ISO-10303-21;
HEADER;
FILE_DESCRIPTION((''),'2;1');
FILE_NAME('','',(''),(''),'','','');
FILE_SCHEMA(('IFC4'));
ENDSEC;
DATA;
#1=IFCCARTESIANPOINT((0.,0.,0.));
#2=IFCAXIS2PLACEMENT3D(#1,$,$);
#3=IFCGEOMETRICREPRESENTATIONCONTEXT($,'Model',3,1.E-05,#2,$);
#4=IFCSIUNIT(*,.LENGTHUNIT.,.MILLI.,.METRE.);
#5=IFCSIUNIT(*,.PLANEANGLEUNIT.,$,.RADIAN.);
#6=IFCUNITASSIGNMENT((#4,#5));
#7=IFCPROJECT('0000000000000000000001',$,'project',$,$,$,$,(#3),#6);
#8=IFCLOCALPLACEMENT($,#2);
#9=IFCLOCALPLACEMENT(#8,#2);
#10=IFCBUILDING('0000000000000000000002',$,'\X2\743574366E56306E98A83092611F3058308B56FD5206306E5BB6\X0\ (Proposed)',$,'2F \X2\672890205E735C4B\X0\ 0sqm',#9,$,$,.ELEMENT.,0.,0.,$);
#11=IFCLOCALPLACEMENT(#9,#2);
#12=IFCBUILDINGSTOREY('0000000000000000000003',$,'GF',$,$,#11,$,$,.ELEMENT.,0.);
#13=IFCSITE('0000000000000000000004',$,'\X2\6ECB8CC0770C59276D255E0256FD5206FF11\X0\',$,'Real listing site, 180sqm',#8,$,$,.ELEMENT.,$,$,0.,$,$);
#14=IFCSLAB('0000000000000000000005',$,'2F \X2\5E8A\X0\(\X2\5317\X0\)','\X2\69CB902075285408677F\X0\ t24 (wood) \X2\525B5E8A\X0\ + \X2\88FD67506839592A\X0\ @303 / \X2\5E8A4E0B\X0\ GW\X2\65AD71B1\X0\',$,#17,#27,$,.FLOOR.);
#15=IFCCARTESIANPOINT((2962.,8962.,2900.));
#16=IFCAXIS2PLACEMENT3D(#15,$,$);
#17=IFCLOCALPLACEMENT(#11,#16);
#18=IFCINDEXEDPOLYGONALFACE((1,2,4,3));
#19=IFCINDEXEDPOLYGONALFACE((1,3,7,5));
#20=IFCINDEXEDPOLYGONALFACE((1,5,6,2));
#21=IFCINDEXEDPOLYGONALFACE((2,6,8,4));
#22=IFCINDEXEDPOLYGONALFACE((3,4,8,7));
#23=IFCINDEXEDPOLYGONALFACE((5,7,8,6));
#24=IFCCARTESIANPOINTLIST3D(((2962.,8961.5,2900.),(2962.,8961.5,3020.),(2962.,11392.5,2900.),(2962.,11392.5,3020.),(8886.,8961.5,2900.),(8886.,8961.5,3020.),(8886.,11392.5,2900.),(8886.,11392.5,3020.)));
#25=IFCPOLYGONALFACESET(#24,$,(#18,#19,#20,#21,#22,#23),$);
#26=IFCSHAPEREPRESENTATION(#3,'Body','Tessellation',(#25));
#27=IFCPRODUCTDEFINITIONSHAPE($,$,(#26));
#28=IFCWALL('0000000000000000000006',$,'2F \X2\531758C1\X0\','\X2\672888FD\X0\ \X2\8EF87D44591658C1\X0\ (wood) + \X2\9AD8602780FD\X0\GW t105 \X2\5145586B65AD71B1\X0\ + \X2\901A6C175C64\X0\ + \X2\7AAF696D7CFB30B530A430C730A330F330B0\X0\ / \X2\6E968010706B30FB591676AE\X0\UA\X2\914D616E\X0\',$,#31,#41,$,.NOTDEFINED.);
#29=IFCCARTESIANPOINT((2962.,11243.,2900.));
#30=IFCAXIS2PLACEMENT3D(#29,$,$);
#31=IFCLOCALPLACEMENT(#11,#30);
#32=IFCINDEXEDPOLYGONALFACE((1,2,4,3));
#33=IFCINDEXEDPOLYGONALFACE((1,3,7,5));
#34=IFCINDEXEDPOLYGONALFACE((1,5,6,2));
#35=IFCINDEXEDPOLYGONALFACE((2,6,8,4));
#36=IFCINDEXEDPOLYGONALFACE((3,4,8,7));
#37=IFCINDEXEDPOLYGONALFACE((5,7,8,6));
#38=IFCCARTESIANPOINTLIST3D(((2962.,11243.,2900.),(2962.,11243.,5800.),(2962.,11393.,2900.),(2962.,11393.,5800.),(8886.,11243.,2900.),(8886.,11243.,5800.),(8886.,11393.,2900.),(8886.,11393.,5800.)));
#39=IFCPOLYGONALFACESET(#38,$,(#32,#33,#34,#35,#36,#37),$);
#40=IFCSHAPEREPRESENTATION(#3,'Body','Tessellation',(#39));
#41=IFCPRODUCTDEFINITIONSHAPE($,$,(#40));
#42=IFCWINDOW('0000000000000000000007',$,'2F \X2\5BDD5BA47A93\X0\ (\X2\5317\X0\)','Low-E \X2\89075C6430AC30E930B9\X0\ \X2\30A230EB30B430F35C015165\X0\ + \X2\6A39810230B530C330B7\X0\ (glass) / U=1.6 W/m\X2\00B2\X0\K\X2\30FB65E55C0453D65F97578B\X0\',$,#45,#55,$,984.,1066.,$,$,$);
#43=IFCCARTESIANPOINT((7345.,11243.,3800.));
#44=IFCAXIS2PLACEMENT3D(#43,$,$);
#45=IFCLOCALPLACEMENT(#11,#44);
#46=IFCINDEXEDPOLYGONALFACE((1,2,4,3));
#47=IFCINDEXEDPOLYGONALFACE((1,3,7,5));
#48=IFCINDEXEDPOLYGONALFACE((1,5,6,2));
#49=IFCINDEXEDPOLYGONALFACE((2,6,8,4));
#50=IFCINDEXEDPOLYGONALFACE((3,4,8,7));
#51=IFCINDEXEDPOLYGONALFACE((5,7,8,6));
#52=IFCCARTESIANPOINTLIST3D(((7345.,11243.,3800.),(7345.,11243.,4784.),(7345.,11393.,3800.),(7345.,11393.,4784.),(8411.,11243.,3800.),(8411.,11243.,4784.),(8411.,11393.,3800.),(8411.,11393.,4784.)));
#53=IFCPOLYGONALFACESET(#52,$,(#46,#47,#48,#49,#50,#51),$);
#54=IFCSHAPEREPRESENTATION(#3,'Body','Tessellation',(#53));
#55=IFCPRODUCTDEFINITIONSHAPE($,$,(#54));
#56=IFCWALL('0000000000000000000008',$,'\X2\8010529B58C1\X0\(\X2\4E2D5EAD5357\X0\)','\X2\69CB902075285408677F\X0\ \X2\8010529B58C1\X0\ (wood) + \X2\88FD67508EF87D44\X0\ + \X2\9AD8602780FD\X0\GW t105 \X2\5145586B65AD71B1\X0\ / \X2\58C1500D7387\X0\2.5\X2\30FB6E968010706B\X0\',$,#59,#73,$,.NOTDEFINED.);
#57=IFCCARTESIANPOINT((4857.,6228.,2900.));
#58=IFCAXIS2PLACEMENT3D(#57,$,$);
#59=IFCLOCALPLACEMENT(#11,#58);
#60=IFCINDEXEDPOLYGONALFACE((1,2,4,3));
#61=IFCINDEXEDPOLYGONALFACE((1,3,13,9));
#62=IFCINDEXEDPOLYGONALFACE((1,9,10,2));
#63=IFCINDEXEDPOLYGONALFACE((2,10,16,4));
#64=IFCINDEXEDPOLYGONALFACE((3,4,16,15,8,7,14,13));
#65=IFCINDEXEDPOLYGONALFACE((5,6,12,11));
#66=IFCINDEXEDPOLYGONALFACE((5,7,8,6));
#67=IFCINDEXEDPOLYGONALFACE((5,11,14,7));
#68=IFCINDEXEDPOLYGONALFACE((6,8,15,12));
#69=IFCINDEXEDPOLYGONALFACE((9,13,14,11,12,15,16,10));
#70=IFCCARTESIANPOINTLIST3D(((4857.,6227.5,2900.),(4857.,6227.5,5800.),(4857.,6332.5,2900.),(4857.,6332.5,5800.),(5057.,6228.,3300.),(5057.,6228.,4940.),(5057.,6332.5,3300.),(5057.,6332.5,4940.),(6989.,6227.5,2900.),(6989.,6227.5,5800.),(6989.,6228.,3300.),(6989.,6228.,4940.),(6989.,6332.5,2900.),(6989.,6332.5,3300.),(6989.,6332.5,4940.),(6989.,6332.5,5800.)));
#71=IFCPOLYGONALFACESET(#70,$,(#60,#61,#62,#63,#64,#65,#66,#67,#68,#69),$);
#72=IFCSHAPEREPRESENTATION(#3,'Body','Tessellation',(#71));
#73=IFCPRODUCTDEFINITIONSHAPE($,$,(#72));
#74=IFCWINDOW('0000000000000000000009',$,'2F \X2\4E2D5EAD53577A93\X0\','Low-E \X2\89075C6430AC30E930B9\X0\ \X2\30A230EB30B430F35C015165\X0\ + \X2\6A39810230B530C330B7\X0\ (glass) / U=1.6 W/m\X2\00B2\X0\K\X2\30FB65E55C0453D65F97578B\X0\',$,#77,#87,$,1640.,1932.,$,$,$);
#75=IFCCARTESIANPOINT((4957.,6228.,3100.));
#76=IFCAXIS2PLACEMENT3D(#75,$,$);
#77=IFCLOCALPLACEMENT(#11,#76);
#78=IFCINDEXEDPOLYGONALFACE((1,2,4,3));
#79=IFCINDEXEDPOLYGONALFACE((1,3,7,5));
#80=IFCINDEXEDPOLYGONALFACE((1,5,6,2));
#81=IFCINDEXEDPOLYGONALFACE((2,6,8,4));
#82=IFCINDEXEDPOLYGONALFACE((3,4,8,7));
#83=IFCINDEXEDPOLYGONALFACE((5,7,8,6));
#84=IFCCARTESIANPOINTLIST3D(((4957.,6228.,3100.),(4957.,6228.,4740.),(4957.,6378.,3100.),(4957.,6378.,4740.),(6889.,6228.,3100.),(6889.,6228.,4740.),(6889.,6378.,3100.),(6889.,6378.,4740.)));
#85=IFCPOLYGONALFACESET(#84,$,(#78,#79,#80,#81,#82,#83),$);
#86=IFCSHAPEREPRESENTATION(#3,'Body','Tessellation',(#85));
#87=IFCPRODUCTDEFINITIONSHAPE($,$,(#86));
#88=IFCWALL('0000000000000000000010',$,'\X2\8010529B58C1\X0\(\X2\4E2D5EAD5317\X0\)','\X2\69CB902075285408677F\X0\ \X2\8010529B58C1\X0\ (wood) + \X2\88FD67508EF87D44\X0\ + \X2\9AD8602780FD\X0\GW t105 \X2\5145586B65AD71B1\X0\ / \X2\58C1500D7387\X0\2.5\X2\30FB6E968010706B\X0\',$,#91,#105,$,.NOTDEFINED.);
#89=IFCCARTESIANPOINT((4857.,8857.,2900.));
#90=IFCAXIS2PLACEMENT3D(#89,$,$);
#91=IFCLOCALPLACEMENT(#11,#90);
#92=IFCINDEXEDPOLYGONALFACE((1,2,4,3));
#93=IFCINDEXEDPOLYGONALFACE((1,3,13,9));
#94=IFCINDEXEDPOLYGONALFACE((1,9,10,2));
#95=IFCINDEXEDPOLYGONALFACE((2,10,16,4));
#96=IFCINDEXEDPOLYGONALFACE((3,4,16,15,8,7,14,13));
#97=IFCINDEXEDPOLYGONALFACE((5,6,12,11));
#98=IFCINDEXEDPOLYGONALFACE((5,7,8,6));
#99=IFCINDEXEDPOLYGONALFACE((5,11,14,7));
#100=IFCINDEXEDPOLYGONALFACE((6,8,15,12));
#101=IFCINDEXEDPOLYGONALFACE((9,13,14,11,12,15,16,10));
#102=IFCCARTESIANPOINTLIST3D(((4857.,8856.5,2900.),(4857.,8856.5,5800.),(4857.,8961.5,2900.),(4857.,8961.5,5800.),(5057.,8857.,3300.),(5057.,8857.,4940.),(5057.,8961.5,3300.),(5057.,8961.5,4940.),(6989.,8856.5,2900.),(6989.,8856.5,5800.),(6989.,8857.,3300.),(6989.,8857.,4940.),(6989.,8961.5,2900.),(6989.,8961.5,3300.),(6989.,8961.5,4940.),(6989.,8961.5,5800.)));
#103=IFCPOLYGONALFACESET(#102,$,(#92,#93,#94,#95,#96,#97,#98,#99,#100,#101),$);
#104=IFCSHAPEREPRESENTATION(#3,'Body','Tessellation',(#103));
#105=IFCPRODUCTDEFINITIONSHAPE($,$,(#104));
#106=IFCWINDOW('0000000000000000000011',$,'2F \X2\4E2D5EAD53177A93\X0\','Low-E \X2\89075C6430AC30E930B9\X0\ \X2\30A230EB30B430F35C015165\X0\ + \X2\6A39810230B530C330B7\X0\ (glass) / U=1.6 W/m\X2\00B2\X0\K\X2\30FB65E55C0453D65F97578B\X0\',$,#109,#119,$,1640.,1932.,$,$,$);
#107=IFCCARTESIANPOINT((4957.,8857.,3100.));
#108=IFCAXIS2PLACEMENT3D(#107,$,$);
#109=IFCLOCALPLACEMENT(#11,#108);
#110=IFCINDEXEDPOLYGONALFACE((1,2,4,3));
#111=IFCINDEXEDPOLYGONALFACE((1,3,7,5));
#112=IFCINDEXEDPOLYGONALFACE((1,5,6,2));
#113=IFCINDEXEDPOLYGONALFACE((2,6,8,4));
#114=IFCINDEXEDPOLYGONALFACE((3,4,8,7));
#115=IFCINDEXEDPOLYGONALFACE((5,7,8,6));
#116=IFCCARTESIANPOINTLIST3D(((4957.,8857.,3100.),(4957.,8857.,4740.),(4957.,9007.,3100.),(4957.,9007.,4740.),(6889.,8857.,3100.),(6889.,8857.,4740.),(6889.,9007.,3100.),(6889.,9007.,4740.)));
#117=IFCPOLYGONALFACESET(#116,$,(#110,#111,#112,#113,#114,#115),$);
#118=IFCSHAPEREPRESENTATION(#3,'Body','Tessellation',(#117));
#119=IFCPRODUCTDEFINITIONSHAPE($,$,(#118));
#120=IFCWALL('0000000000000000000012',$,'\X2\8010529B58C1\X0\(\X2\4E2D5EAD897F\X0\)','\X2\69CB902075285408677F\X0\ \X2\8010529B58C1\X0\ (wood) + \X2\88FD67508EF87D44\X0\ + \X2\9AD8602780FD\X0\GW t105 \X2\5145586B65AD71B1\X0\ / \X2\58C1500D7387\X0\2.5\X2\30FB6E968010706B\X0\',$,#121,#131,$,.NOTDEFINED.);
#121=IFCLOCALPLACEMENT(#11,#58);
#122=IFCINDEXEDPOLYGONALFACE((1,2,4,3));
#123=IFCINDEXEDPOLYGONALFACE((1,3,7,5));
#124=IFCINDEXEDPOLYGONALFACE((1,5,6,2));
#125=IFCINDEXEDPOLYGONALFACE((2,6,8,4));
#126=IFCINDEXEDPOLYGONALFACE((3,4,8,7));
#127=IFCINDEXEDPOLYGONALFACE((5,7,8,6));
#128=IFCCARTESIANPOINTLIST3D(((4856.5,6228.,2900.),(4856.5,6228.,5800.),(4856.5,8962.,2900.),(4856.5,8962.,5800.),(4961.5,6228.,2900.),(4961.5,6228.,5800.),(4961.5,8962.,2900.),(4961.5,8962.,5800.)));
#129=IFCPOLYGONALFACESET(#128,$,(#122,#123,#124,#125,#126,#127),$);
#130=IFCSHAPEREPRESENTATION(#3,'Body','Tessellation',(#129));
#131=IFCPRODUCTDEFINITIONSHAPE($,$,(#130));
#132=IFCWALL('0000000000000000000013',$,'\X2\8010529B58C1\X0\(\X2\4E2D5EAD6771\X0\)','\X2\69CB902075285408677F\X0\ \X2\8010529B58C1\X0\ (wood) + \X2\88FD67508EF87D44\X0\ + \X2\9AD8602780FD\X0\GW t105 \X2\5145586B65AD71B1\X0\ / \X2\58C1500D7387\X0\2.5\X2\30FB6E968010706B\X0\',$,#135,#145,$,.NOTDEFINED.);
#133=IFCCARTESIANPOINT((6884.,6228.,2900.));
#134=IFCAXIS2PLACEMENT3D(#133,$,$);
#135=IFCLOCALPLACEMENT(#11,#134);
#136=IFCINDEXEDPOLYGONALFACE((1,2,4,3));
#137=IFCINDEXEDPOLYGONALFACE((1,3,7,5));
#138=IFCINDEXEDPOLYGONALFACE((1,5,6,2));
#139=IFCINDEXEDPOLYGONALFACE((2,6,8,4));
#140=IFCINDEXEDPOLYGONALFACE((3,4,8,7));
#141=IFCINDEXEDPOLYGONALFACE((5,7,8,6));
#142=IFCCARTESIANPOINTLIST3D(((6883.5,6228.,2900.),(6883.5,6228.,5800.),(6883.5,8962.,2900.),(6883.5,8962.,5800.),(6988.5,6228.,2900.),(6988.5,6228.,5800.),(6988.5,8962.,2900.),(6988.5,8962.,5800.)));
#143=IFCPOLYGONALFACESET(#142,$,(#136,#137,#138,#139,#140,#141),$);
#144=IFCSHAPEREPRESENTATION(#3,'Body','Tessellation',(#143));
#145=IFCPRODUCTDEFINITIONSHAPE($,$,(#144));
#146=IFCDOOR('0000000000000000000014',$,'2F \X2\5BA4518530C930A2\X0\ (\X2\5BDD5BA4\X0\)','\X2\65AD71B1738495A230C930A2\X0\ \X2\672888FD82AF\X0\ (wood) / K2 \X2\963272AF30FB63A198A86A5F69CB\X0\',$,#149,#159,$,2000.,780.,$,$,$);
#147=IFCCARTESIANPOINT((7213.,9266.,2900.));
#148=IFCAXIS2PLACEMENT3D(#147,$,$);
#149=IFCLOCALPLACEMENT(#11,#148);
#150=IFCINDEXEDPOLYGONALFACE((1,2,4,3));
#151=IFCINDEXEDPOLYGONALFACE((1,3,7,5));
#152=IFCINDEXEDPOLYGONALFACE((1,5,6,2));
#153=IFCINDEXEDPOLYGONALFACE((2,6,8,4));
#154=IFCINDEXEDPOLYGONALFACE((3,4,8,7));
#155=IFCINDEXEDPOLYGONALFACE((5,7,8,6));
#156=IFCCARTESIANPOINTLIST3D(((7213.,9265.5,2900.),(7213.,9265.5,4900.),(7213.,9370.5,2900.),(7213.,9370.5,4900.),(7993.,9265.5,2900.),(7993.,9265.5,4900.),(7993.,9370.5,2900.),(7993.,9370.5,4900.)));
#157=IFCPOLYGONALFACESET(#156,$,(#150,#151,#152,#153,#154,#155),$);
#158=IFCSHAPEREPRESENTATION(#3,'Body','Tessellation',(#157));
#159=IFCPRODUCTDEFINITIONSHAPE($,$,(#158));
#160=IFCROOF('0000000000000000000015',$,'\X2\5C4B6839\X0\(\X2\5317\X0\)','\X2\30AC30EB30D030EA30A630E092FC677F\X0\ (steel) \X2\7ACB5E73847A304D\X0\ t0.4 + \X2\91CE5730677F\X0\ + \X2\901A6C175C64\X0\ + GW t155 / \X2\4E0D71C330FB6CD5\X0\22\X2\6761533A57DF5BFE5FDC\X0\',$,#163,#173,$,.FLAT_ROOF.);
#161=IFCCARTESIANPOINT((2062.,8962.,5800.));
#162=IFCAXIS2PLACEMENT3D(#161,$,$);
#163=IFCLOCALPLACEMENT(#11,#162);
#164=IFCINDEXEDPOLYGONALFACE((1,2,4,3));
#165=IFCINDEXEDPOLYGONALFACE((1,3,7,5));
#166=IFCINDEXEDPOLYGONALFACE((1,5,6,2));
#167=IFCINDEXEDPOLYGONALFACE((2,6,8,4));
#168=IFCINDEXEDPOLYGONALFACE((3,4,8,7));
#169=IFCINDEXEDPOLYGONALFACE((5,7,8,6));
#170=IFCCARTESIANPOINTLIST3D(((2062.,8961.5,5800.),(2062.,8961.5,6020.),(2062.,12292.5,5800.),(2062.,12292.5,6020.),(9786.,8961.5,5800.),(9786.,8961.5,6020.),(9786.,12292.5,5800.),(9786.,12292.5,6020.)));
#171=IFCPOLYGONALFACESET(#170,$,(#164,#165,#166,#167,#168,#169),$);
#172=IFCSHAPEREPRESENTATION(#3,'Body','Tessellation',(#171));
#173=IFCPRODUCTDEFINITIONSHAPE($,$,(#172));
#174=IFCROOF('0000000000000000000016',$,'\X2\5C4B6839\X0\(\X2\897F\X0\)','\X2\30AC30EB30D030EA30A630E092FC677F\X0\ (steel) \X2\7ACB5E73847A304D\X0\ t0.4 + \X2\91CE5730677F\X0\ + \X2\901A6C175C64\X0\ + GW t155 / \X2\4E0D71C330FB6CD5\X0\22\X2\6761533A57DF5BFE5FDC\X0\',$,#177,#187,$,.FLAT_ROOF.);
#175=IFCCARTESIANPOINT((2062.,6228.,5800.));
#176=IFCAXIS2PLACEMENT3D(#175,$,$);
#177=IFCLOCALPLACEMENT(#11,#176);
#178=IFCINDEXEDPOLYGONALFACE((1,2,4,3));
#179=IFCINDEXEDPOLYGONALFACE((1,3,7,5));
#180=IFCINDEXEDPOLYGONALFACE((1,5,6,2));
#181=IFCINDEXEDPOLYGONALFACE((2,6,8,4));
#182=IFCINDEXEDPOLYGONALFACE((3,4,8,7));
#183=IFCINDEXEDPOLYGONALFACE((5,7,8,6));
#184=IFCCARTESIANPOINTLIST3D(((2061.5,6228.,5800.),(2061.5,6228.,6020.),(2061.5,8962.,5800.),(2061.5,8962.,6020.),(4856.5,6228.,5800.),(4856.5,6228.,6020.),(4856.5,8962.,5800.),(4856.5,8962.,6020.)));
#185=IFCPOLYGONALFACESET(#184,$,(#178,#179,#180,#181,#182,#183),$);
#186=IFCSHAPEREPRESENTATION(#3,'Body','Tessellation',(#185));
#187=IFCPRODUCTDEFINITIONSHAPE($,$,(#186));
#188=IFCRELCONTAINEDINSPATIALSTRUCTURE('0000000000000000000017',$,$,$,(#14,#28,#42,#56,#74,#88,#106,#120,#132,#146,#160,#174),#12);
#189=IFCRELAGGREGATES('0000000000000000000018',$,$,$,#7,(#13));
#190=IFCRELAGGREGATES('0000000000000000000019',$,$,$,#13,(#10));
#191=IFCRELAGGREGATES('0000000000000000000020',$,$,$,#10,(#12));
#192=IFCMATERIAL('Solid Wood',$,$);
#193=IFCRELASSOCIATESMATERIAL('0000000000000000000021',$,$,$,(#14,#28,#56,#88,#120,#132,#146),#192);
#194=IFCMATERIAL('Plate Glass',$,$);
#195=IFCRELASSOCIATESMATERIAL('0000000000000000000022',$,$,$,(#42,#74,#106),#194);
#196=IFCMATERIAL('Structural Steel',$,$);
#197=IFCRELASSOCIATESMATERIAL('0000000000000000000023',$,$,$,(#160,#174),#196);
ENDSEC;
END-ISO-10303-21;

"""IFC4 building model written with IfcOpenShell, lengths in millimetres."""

from ifc_helpers import new_model, si_unit, frame, frame_2d, origin, place, context, project, spatial, rectangle, extrude, material, element, fill, save


model = new_model("IFC4")

# Units and contexts
model_context = context("Model", 3, precision=1e-05, world=origin())
ifc_project = project(units=[si_unit("LENGTHUNIT", "METRE", prefix="MILLI"), si_unit("PLANEANGLEUNIT", "RADIAN")], contexts=[model_context])

# Site, building, storey
site_placement = place(None, origin())
site = spatial("IfcSite", under=ifc_project, at=site_placement, Name="滋賀県大津市国分１", ObjectType="Real listing site, 180sqm", CompositionType="ELEMENT", RefElevation=0.0)
building_placement = place(site_placement, origin())
building = spatial("IfcBuilding", under=site, at=building_placement, Name="琵琶湖の風を感じる国分の家 (Proposed)", ObjectType="2F 木造平屋 0sqm", CompositionType="ELEMENT", ElevationOfRefHeight=0.0, ElevationOfTerrain=0.0)
storey_placement = place(building_placement, origin())
storey = spatial("IfcBuildingStorey", under=building, at=storey_placement, Name="GF", CompositionType="ELEMENT", Elevation=0.0)

# Slab
ifc_material_1 = material(Name="Solid Wood")
slab_placement = place(storey_placement, frame((2962.0, 8962.0, 2900.0)))
element("IfcSlab", 1, at=slab_placement, inside=storey, material=ifc_material_1, Name="2F 床(北)", Description="構造用合板 t24 (wood) 剛床 + 製材根太 @303 / 床下 GW断熱", PredefinedType="FLOOR", context=model_context, shape_type="SweptSolid", body=[
    extrude(rectangle(XDim=5924.0, YDim=2431.0, at=frame_2d((2962.0, 1215.0))), frame((2962.0, 8962.0, 2900.0)), (0.0, 0.0, 1.0), 120.0),
])

# Walls, openings, windows
wall_1_placement = place(storey_placement, frame((2962.0, 11243.0, 2900.0)))
wall_1 = element("IfcWall", 2, at=wall_1_placement, inside=storey, material=ifc_material_1, Name="2F 北壁", Description="木製 軸組外壁 (wood) + 高性能GW t105 充填断熱 + 通気層 + 窯業系サイディング / 準耐火・外皮UA配慮", PredefinedType="NOTDEFINED", context=model_context, shape_type="SweptSolid", body=[
    extrude(rectangle(XDim=5924.0, YDim=150.0, at=frame_2d((2962.0, 75.0))), frame((2962.0, 11243.0, 2900.0)), (0.0, 0.0, 1.0), 2900.0),
])
opening_1_placement = place(storey_placement, frame((7345.0, 11243.0, 3800.0)))
opening_1 = element("IfcOpeningElement", 3, at=opening_1_placement, cuts=wall_1, PredefinedType="NOTDEFINED", context=model_context, shape_type="SweptSolid", body=[
    extrude(rectangle(XDim=1066.0, YDim=150.0, at=frame_2d((533.0, 75.0))), frame((7345.0, 11243.0, 3800.0)), (0.0, 0.0, 1.0), 984.0),
])
ifc_material_2 = material(Name="Plate Glass")
window_1_placement = place(storey_placement, frame((7345.0, 11243.0, 3800.0)))
window_1 = element("IfcWindow", 4, at=window_1_placement, inside=storey, material=ifc_material_2, Name="2F 寝室窓 (北)", Description="Low-E 複層ガラス アルゴン封入 + 樹脂サッシ (glass) / U=1.6 W/m²K・日射取得型", OverallHeight=984.0, OverallWidth=1066.0, context=model_context, shape_type="SweptSolid", body=[
    extrude(rectangle(XDim=1066.0, YDim=150.0, at=frame_2d((533.0, 75.0))), frame((7345.0, 11243.0, 3800.0)), (0.0, 0.0, 1.0), 984.0),
])
fill(opening_1, window_1)
wall_2_placement = place(storey_placement, frame((4857.0, 6228.0, 2900.0)))
wall_2 = element("IfcWall", 5, at=wall_2_placement, inside=storey, material=ifc_material_1, Name="耐力壁(中庭南)", Description="構造用合板 耐力壁 (wood) + 製材軸組 + 高性能GW t105 充填断熱 / 壁倍率2.5・準耐火", PredefinedType="NOTDEFINED", context=model_context, shape_type="SweptSolid", body=[
    extrude(rectangle(XDim=2132.0, YDim=105.0, at=frame_2d((1066.0, 52.0))), frame((4857.0, 6228.0, 2900.0)), (0.0, 0.0, 1.0), 2900.0),
])
opening_2_placement = place(storey_placement, frame((4957.0, 6228.0, 3100.0)))
opening_2 = element("IfcOpeningElement", 6, at=opening_2_placement, cuts=wall_2, PredefinedType="NOTDEFINED", context=model_context, shape_type="SweptSolid", body=[
    extrude(rectangle(XDim=1932.0, YDim=150.0, at=frame_2d((966.0, 75.0))), frame((4957.0, 6228.0, 3100.0)), (0.0, 0.0, 1.0), 1640.0),
])
window_2_placement = place(storey_placement, frame((4957.0, 6228.0, 3100.0)))
window_2 = element("IfcWindow", 7, at=window_2_placement, inside=storey, material=ifc_material_2, Name="2F 中庭南窓", Description="Low-E 複層ガラス アルゴン封入 + 樹脂サッシ (glass) / U=1.6 W/m²K・日射取得型", OverallHeight=1640.0, OverallWidth=1932.0, context=model_context, shape_type="SweptSolid", body=[
    extrude(rectangle(XDim=1932.0, YDim=150.0, at=frame_2d((966.0, 75.0))), frame((4957.0, 6228.0, 3100.0)), (0.0, 0.0, 1.0), 1640.0),
])
fill(opening_2, window_2)
wall_3_placement = place(storey_placement, frame((4857.0, 8857.0, 2900.0)))
wall_3 = element("IfcWall", 8, at=wall_3_placement, inside=storey, material=ifc_material_1, Name="耐力壁(中庭北)", Description="構造用合板 耐力壁 (wood) + 製材軸組 + 高性能GW t105 充填断熱 / 壁倍率2.5・準耐火", PredefinedType="NOTDEFINED", context=model_context, shape_type="SweptSolid", body=[
    extrude(rectangle(XDim=2132.0, YDim=105.0, at=frame_2d((1066.0, 52.0))), frame((4857.0, 8857.0, 2900.0)), (0.0, 0.0, 1.0), 2900.0),
])
opening_3_placement = place(storey_placement, frame((4957.0, 8857.0, 3100.0)))
opening_3 = element("IfcOpeningElement", 9, at=opening_3_placement, cuts=wall_3, PredefinedType="NOTDEFINED", context=model_context, shape_type="SweptSolid", body=[
    extrude(rectangle(XDim=1932.0, YDim=150.0, at=frame_2d((966.0, 75.0))), frame((4957.0, 8857.0, 3100.0)), (0.0, 0.0, 1.0), 1640.0),
])
window_3_placement = place(storey_placement, frame((4957.0, 8857.0, 3100.0)))
window_3 = element("IfcWindow", 10, at=window_3_placement, inside=storey, material=ifc_material_2, Name="2F 中庭北窓", Description="Low-E 複層ガラス アルゴン封入 + 樹脂サッシ (glass) / U=1.6 W/m²K・日射取得型", OverallHeight=1640.0, OverallWidth=1932.0, context=model_context, shape_type="SweptSolid", body=[
    extrude(rectangle(XDim=1932.0, YDim=150.0, at=frame_2d((966.0, 75.0))), frame((4957.0, 8857.0, 3100.0)), (0.0, 0.0, 1.0), 1640.0),
])
fill(opening_3, window_3)

# Walls
wall_4_placement = place(storey_placement, frame((4857.0, 6228.0, 2900.0)))
element("IfcWall", 11, at=wall_4_placement, inside=storey, material=ifc_material_1, Name="耐力壁(中庭西)", Description="構造用合板 耐力壁 (wood) + 製材軸組 + 高性能GW t105 充填断熱 / 壁倍率2.5・準耐火", PredefinedType="NOTDEFINED", context=model_context, shape_type="SweptSolid", body=[
    extrude(rectangle(XDim=105.0, YDim=2734.0, at=frame_2d((52.0, 1367.0))), frame((4857.0, 6228.0, 2900.0)), (0.0, 0.0, 1.0), 2900.0),
])
wall_5_placement = place(storey_placement, frame((6884.0, 6228.0, 2900.0)))
element("IfcWall", 12, at=wall_5_placement, inside=storey, material=ifc_material_1, Name="耐力壁(中庭東)", Description="構造用合板 耐力壁 (wood) + 製材軸組 + 高性能GW t105 充填断熱 / 壁倍率2.5・準耐火", PredefinedType="NOTDEFINED", context=model_context, shape_type="SweptSolid", body=[
    extrude(rectangle(XDim=105.0, YDim=2734.0, at=frame_2d((52.0, 1367.0))), frame((6884.0, 6228.0, 2900.0)), (0.0, 0.0, 1.0), 2900.0),
])

# Door
door_placement = place(storey_placement, frame((7213.0, 9266.0, 2900.0)))
element("IfcDoor", 13, at=door_placement, inside=storey, material=ifc_material_1, Name="2F 室内ドア (寝室)", Description="断熱玄関ドア 木製芯 (wood) / K2 防犯・採風機構", OverallHeight=2000.0, OverallWidth=780.0, context=model_context, shape_type="SweptSolid", body=[
    extrude(rectangle(XDim=780.0, YDim=105.0, at=frame_2d((390.0, 52.0))), frame((7213.0, 9266.0, 2900.0)), (0.0, 0.0, 1.0), 2000.0),
])

# Roofs
ifc_material_3 = material(Name="Structural Steel")
for number, where, name in (
    (14, (2062.0, 8962.0, 5800.0), "屋根(北)"),
):
    element("IfcRoof", number, at=place(storey_placement, frame(where)), inside=storey, material=ifc_material_3, Name=name, Description="ガルバリウム鋼板 (steel) 立平葺き t0.4 + 野地板 + 通気層 + GW t155 / 不燃・法22条区域対応", PredefinedType="FLAT_ROOF", context=model_context, shape_type="SweptSolid", body=[
        extrude(rectangle(XDim=7724.0, YDim=3331.0, at=frame_2d((3862.0, 1665.0))), frame((2062.0, 8962.0, 5800.0)), (0.0, 0.0, 1.0), 220.0),
    ])
roof_1_placement = place(storey_placement, frame((2062.0, 6228.0, 5800.0)))
element("IfcRoof", 15, at=roof_1_placement, inside=storey, material=ifc_material_3, Name="屋根(西)", Description="ガルバリウム鋼板 (steel) 立平葺き t0.4 + 野地板 + 通気層 + GW t155 / 不燃・法22条区域対応", PredefinedType="FLAT_ROOF", context=model_context, shape_type="SweptSolid", body=[
    extrude(rectangle(XDim=2795.0, YDim=2734.0, at=frame_2d((1397.0, 1367.0))), frame((2062.0, 6228.0, 5800.0)), (0.0, 0.0, 1.0), 220.0),
])

save(model, "model.ifc")
